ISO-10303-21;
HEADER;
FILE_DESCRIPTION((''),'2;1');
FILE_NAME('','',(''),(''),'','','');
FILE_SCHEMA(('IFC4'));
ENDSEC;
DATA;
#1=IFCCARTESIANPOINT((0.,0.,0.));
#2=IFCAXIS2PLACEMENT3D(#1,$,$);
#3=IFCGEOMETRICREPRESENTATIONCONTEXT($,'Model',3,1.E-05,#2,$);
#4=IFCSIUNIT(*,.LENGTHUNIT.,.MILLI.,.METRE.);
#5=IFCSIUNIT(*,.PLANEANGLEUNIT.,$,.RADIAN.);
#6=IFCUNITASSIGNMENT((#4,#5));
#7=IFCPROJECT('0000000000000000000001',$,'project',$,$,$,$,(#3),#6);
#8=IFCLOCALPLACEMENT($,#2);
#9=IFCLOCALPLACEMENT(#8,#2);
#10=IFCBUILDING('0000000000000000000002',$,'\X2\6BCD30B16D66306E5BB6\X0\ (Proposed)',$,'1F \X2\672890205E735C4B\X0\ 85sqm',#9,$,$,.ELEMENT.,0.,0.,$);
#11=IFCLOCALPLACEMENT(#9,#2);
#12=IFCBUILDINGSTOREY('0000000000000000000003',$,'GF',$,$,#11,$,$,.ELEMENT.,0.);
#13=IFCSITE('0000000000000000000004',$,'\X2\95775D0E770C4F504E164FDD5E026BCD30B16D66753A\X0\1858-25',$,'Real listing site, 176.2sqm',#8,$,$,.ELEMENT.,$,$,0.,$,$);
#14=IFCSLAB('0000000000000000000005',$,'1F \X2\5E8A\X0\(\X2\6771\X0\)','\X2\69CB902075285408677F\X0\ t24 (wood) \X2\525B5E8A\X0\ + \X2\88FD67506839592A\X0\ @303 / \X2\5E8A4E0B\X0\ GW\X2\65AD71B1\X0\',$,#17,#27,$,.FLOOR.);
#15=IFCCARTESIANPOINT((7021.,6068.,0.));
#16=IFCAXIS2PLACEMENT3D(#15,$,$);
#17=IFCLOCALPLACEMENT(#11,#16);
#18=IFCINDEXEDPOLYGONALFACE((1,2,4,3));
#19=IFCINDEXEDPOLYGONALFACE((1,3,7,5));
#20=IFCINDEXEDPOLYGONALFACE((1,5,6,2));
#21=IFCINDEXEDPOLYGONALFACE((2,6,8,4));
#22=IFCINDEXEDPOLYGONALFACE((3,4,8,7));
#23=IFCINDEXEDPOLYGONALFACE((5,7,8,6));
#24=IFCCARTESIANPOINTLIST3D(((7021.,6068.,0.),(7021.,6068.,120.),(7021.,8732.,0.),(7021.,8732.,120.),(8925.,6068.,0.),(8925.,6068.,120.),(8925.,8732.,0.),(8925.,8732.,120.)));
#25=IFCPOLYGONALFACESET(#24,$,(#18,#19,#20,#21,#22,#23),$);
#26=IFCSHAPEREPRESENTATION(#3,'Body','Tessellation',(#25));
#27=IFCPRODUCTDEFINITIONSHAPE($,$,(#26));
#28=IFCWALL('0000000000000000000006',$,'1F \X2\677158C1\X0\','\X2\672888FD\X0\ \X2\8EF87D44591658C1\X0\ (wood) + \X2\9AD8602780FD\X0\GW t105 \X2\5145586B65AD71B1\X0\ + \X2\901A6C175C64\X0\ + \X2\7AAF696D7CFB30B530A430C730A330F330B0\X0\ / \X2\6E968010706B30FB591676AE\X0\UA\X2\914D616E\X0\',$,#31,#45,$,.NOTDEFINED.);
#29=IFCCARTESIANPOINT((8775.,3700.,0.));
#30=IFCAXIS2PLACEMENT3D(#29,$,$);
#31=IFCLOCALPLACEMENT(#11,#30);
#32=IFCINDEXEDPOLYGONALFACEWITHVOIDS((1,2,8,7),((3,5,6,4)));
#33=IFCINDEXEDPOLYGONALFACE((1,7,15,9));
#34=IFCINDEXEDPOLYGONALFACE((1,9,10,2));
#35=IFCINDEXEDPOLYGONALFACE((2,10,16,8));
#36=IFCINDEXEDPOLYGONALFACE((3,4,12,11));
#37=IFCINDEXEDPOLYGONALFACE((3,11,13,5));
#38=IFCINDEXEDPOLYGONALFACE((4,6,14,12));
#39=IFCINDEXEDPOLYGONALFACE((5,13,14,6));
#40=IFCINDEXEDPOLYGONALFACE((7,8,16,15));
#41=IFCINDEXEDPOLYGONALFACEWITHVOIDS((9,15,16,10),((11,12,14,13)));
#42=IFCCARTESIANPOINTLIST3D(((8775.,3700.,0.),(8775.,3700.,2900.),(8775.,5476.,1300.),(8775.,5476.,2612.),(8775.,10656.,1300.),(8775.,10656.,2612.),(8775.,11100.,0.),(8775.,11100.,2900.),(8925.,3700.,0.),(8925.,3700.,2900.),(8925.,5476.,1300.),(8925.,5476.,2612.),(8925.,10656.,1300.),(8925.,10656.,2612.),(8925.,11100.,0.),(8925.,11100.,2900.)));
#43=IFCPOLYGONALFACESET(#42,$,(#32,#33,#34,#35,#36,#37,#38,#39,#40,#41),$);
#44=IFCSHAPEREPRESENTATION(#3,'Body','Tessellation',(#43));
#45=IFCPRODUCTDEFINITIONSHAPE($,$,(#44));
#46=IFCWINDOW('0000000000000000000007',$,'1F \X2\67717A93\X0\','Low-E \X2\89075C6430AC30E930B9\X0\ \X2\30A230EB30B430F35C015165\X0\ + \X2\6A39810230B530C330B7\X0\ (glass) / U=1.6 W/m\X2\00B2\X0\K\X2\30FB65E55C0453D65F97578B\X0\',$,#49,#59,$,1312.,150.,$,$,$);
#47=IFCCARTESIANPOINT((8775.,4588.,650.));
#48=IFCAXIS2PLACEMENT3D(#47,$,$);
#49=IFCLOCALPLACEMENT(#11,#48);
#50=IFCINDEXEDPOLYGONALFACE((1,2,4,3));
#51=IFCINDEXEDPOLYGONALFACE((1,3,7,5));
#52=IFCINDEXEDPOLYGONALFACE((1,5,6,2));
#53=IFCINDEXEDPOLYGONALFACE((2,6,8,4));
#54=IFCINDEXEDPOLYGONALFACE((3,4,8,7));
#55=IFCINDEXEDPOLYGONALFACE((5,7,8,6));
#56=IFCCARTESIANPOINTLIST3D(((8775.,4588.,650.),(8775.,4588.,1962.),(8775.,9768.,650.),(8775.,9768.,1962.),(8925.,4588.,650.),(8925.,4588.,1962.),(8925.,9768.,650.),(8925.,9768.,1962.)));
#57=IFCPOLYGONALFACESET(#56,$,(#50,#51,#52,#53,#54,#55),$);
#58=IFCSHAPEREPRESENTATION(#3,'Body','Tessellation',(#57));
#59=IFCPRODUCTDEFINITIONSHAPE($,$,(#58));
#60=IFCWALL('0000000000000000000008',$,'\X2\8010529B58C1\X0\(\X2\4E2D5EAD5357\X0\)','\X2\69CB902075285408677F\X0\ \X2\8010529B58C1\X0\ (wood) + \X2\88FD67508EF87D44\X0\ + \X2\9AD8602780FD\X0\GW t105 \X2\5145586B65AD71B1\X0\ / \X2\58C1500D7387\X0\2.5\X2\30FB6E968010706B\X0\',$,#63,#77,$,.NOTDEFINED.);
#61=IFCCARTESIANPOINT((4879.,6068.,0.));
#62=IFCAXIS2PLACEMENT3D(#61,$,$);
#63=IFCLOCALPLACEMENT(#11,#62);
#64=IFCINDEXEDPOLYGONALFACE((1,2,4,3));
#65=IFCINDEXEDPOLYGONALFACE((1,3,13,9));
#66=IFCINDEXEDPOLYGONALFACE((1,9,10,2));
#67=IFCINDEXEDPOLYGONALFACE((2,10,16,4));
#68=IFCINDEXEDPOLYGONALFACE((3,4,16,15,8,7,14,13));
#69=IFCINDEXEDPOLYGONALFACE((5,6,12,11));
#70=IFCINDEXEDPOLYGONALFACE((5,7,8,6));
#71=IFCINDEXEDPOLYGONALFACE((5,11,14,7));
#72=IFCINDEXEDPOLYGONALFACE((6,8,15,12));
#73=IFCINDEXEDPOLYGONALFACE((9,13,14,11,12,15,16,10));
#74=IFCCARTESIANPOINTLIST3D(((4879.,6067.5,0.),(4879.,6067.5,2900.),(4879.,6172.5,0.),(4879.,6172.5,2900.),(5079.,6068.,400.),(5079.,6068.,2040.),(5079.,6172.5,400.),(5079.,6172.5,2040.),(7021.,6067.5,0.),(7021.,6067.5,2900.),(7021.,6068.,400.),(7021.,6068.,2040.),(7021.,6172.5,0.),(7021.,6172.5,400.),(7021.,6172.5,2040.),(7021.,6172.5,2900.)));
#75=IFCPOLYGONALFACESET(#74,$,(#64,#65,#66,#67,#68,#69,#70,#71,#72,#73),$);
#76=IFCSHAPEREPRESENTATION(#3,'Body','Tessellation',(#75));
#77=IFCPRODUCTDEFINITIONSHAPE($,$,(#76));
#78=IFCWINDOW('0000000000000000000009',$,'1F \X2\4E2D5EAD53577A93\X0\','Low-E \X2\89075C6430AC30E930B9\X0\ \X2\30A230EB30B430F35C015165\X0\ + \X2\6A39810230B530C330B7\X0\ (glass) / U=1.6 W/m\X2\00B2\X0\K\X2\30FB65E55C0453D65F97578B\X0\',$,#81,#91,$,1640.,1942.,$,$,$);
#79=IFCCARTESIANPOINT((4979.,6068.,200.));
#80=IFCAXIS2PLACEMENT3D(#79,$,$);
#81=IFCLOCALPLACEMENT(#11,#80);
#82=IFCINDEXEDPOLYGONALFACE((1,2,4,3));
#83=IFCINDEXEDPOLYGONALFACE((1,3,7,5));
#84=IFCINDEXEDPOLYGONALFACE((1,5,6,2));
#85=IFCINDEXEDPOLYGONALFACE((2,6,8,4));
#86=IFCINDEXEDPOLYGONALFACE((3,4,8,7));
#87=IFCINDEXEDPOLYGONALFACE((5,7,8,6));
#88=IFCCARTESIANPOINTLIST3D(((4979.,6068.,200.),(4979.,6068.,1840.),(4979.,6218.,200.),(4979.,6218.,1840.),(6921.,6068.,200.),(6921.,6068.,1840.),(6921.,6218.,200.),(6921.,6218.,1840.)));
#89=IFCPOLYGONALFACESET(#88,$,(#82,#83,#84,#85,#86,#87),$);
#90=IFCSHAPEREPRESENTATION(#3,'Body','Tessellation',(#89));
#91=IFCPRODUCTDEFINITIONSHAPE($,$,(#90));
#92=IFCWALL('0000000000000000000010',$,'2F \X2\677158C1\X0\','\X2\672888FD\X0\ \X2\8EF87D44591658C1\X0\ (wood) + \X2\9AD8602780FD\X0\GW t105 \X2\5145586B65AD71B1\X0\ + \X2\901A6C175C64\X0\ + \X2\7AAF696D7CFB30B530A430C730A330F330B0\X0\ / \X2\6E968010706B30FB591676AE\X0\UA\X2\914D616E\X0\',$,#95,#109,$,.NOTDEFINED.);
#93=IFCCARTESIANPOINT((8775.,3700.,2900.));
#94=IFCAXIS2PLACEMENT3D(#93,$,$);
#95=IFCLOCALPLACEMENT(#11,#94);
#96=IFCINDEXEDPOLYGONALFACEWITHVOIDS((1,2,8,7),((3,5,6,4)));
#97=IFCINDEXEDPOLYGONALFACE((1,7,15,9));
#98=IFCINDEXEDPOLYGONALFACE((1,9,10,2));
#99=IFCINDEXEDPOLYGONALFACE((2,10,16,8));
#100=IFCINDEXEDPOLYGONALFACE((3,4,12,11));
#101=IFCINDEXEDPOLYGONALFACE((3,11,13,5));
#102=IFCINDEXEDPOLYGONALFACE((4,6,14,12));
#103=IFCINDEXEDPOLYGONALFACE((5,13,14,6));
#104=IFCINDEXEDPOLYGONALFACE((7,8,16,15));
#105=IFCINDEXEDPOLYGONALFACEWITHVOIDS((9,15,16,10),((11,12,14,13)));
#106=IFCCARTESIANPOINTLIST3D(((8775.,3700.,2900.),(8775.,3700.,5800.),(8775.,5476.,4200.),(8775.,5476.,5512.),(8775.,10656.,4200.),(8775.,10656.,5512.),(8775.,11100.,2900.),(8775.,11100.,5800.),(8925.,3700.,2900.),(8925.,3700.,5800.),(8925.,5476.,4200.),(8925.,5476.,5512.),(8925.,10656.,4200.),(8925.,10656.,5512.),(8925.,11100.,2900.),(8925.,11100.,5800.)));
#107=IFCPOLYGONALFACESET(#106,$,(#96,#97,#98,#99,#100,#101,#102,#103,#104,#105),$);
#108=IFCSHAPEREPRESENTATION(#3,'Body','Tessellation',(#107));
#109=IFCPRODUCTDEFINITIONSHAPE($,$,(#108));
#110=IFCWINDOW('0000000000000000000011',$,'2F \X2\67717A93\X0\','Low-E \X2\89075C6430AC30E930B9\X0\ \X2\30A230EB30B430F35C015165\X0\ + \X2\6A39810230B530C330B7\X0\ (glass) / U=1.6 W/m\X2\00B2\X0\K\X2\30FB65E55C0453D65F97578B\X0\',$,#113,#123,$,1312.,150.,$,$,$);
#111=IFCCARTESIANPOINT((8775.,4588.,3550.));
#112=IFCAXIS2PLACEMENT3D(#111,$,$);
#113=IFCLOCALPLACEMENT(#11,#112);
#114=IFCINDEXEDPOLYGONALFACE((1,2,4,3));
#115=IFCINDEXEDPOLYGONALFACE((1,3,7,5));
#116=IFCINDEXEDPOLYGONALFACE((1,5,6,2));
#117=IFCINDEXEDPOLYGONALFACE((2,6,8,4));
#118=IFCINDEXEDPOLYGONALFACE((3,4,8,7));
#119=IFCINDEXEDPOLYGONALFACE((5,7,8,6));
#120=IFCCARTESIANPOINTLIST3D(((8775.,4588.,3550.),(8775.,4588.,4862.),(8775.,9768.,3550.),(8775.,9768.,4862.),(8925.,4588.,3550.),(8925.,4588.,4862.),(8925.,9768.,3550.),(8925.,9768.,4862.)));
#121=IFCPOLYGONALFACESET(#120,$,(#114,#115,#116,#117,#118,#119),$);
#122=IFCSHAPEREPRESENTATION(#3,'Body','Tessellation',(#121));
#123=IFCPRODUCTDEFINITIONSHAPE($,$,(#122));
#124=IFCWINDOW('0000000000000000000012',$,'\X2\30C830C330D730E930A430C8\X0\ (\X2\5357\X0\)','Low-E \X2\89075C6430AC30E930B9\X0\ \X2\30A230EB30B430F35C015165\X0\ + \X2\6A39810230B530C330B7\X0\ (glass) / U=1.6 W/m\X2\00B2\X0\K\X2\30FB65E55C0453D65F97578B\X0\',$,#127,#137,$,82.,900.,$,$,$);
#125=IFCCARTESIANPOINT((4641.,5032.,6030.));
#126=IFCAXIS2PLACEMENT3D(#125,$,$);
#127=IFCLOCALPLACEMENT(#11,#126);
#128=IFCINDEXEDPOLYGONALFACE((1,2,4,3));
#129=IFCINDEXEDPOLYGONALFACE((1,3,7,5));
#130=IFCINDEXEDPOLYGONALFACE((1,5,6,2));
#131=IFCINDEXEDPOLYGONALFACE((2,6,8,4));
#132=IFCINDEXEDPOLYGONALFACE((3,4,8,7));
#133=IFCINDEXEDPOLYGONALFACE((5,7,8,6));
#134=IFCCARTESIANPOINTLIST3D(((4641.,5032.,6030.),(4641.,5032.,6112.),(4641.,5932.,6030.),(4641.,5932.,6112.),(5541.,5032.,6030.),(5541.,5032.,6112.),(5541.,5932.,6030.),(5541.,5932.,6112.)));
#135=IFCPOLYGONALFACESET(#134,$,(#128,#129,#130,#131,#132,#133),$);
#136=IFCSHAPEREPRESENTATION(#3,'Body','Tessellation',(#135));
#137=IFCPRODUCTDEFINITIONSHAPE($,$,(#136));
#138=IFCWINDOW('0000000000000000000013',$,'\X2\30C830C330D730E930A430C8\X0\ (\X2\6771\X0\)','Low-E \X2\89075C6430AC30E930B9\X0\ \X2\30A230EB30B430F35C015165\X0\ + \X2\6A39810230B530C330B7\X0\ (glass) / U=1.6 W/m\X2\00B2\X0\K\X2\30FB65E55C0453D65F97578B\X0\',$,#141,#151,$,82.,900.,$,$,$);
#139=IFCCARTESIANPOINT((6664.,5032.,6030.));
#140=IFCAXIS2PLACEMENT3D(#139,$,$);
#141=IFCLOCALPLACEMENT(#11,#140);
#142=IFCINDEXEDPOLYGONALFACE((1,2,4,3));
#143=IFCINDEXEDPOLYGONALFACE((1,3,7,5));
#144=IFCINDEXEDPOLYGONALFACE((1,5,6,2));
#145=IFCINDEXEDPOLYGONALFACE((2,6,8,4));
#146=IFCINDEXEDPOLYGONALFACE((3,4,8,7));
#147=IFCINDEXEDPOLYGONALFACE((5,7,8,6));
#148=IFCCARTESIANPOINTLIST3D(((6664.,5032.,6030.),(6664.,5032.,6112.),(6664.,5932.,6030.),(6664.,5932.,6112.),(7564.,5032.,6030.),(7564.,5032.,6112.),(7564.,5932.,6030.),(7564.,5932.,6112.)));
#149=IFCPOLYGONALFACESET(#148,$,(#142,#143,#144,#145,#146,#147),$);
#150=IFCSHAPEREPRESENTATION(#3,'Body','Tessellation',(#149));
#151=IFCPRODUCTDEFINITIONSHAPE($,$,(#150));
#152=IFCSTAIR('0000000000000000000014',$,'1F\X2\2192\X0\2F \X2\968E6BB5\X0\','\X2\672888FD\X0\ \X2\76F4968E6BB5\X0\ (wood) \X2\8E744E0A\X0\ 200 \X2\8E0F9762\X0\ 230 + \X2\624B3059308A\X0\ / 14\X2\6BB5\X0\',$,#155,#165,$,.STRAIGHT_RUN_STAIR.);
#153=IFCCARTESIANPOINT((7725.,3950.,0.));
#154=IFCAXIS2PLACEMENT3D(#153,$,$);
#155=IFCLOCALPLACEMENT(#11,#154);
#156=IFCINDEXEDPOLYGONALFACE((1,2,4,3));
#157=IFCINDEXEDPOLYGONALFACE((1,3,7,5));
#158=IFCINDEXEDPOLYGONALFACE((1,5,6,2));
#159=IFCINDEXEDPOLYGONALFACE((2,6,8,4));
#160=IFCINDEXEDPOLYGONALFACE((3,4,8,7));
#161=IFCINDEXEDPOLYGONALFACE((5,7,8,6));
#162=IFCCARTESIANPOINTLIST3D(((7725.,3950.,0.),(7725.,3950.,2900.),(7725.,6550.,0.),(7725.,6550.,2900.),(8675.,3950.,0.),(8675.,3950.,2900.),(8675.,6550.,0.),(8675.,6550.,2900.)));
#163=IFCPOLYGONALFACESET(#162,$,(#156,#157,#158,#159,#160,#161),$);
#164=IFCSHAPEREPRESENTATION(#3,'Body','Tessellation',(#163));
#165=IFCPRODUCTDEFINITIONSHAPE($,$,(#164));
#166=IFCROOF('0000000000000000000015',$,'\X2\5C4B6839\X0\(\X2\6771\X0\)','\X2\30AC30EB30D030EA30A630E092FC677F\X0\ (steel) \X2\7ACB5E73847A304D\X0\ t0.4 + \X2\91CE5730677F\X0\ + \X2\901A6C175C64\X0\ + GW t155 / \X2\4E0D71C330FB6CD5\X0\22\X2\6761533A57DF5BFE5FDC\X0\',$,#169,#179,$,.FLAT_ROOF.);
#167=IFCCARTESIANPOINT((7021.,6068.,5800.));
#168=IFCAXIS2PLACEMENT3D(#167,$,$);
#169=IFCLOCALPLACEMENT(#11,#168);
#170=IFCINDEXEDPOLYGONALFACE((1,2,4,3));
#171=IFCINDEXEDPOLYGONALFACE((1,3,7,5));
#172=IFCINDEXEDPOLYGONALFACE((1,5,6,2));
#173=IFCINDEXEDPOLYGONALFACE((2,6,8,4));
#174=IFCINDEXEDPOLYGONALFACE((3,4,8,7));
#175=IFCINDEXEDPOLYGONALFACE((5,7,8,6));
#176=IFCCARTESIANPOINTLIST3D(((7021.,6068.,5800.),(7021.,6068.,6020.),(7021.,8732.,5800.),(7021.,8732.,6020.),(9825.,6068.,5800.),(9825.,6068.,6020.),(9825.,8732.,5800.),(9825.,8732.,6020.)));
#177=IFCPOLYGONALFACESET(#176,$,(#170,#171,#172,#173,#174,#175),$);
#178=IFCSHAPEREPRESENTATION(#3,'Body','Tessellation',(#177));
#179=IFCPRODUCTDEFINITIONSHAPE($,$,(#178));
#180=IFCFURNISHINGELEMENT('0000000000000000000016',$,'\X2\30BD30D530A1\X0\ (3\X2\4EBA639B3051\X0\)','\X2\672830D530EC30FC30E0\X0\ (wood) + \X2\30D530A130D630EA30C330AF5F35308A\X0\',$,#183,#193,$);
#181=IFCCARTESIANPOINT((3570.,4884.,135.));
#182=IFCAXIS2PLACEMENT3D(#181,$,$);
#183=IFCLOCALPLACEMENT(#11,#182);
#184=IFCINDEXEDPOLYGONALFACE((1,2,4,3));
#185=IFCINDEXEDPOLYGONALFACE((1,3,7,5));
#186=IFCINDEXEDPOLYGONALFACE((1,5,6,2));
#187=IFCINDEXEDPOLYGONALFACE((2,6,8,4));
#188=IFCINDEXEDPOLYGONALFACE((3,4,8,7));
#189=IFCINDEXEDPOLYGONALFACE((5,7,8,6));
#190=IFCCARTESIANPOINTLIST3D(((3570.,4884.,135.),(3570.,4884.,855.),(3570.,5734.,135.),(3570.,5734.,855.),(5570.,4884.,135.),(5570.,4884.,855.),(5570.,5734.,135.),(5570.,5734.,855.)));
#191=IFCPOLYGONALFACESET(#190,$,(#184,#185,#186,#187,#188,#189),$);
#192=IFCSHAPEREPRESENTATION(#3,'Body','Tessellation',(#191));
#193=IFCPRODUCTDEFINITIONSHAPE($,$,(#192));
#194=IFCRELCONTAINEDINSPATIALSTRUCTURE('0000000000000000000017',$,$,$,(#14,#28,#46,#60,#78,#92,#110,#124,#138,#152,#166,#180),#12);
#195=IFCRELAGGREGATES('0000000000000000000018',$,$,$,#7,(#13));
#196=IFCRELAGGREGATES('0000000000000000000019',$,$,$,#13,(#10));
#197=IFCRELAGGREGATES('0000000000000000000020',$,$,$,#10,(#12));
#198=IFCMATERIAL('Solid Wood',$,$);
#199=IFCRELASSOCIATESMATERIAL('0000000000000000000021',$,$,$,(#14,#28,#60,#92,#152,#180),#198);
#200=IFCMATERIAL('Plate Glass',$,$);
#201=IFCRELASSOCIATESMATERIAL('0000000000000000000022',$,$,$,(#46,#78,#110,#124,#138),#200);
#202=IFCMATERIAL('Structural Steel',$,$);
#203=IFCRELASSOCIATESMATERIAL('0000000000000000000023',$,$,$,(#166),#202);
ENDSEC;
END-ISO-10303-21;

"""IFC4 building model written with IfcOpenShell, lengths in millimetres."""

from ifc_helpers import new_model, si_unit, frame, frame_2d, origin, place, context, project, spatial, rectangle, extrude, material, element, fill, save


model = new_model("IFC4")

# Units and contexts
model_context = context("Model", 3, precision=1e-05, world=origin())
ifc_project = project(units=[si_unit("LENGTHUNIT", "METRE", prefix="MILLI"), si_unit("PLANEANGLEUNIT", "RADIAN")], contexts=[model_context])

# Site, building, storey
site_placement = place(None, origin())
site = spatial("IfcSite", under=ifc_project, at=site_placement, Name="長崎県佐世保市母ケ浦町1858-25", ObjectType="Real listing site, 176.2sqm", CompositionType="ELEMENT", RefElevation=0.0)
building_placement = place(site_placement, origin())
building = spatial("IfcBuilding", under=site, at=building_placement, Name="母ケ浦の家 (Proposed)", ObjectType="1F 木造平屋 85sqm", CompositionType="ELEMENT", ElevationOfRefHeight=0.0, ElevationOfTerrain=0.0)
storey_placement = place(building_placement, origin())
storey = spatial("IfcBuildingStorey", under=building, at=storey_placement, Name="GF", CompositionType="ELEMENT", Elevation=0.0)

# Slab
ifc_material_1 = material(Name="Solid Wood")
slab_placement = place(storey_placement, frame((7021.0, 6068.0, 0.0)))
element("IfcSlab", 1, at=slab_placement, inside=storey, material=ifc_material_1, Name="1F 床(東)", Description="構造用合板 t24 (wood) 剛床 + 製材根太 @303 / 床下 GW断熱", PredefinedType="FLOOR", context=model_context, shape_type="SweptSolid", body=[
    extrude(rectangle(XDim=1904.0, YDim=2664.0, at=frame_2d((952.0, 1332.0))), frame((7021.0, 6068.0, 0.0)), (0.0, 0.0, 1.0), 120.0),
])

# Walls, openings, windows
wall_1_placement = place(storey_placement, frame((8775.0, 3700.0, 0.0)))
wall_1 = element("IfcWall", 2, at=wall_1_placement, inside=storey, material=ifc_material_1, Name="1F 東壁", Description="木製 軸組外壁 (wood) + 高性能GW t105 充填断熱 + 通気層 + 窯業系サイディング / 準耐火・外皮UA配慮", PredefinedType="NOTDEFINED", context=model_context, shape_type="SweptSolid", body=[
    extrude(rectangle(XDim=150.0, YDim=7400.0, at=frame_2d((75.0, 3700.0))), frame((8775.0, 3700.0, 0.0)), (0.0, 0.0, 1.0), 2900.0),
])
opening_1_placement = place(storey_placement, frame((8775.0, 4588.0, 650.0)))
opening_1 = element("IfcOpeningElement", 3, at=opening_1_placement, cuts=wall_1, PredefinedType="NOTDEFINED", context=model_context, shape_type="SweptSolid", body=[
    extrude(rectangle(XDim=150.0, YDim=5180.0, at=frame_2d((75.0, 2590.0))), frame((8775.0, 4588.0, 650.0)), (0.0, 0.0, 1.0), 1312.0),
])
ifc_material_2 = material(Name="Plate Glass")
window_1_placement = place(storey_placement, frame((8775.0, 4588.0, 650.0)))
window_1 = element("IfcWindow", 4, at=window_1_placement, inside=storey, material=ifc_material_2, Name="1F 東窓", Description="Low-E 複層ガラス アルゴン封入 + 樹脂サッシ (glass) / U=1.6 W/m²K・日射取得型", OverallHeight=1312.0, OverallWidth=150.0, context=model_context, shape_type="SweptSolid", body=[
    extrude(rectangle(XDim=150.0, YDim=5180.0, at=frame_2d((75.0, 2590.0))), frame((8775.0, 4588.0, 650.0)), (0.0, 0.0, 1.0), 1312.0),
])
fill(opening_1, window_1)
wall_2_placement = place(storey_placement, frame((4879.0, 6068.0, 0.0)))
wall_2 = element("IfcWall", 5, at=wall_2_placement, inside=storey, material=ifc_material_1, Name="耐力壁(中庭南)", Description="構造用合板 耐力壁 (wood) + 製材軸組 + 高性能GW t105 充填断熱 / 壁倍率2.5・準耐火", PredefinedType="NOTDEFINED", context=model_context, shape_type="SweptSolid", body=[
    extrude(rectangle(XDim=2142.0, YDim=105.0, at=frame_2d((1071.0, 52.0))), frame((4879.0, 6068.0, 0.0)), (0.0, 0.0, 1.0), 2900.0),
])
opening_2_placement = place(storey_placement, frame((4979.0, 6068.0, 200.0)))
opening_2 = element("IfcOpeningElement", 6, at=opening_2_placement, cuts=wall_2, PredefinedType="NOTDEFINED", context=model_context, shape_type="SweptSolid", body=[
    extrude(rectangle(XDim=1942.0, YDim=150.0, at=frame_2d((971.0, 75.0))), frame((4979.0, 6068.0, 200.0)), (0.0, 0.0, 1.0), 1640.0),
])
window_2_placement = place(storey_placement, frame((4979.0, 6068.0, 200.0)))
window_2 = element("IfcWindow", 7, at=window_2_placement, inside=storey, material=ifc_material_2, Name="1F 中庭南窓", Description="Low-E 複層ガラス アルゴン封入 + 樹脂サッシ (glass) / U=1.6 W/m²K・日射取得型", OverallHeight=1640.0, OverallWidth=1942.0, context=model_context, shape_type="SweptSolid", body=[
    extrude(rectangle(XDim=1942.0, YDim=150.0, at=frame_2d((971.0, 75.0))), frame((4979.0, 6068.0, 200.0)), (0.0, 0.0, 1.0), 1640.0),
])
fill(opening_2, window_2)

# Wall, opening, window
wall_3_placement = place(storey_placement, frame((8775.0, 3700.0, 2900.0)))
wall_3 = element("IfcWall", 8, at=wall_3_placement, inside=storey, material=ifc_material_1, Name="2F 東壁", Description="木製 軸組外壁 (wood) + 高性能GW t105 充填断熱 + 通気層 + 窯業系サイディング / 準耐火・外皮UA配慮", PredefinedType="NOTDEFINED", context=model_context, shape_type="SweptSolid", body=[
    extrude(rectangle(XDim=150.0, YDim=7400.0, at=frame_2d((75.0, 3700.0))), frame((8775.0, 3700.0, 2900.0)), (0.0, 0.0, 1.0), 2900.0),
])
opening_3_placement = place(storey_placement, frame((8775.0, 4588.0, 3550.0)))
opening_3 = element("IfcOpeningElement", 9, at=opening_3_placement, cuts=wall_3, PredefinedType="NOTDEFINED", context=model_context, shape_type="SweptSolid", body=[
    extrude(rectangle(XDim=150.0, YDim=5180.0, at=frame_2d((75.0, 2590.0))), frame((8775.0, 4588.0, 3550.0)), (0.0, 0.0, 1.0), 1312.0),
])
window_3_placement = place(storey_placement, frame((8775.0, 4588.0, 3550.0)))
window_3 = element("IfcWindow", 10, at=window_3_placement, inside=storey, material=ifc_material_2, Name="2F 東窓", Description="Low-E 複層ガラス アルゴン封入 + 樹脂サッシ (glass) / U=1.6 W/m²K・日射取得型", OverallHeight=1312.0, OverallWidth=150.0, context=model_context, shape_type="SweptSolid", body=[
    extrude(rectangle(XDim=150.0, YDim=5180.0, at=frame_2d((75.0, 2590.0))), frame((8775.0, 4588.0, 3550.0)), (0.0, 0.0, 1.0), 1312.0),
])
fill(opening_3, window_3)

# Windows
window_4_placement = place(storey_placement, frame((4641.0, 5032.0, 6030.0)))
element("IfcWindow", 11, at=window_4_placement, inside=storey, material=ifc_material_2, Name="トップライト (南)", Description="Low-E 複層ガラス アルゴン封入 + 樹脂サッシ (glass) / U=1.6 W/m²K・日射取得型", OverallHeight=82.0, OverallWidth=900.0, context=model_context, shape_type="SweptSolid", body=[
    extrude(rectangle(XDim=900.0, YDim=900.0, at=frame_2d((450.0, 450.0))), frame((4641.0, 5032.0, 6030.0)), (0.0, 0.0, 1.0), 82.0),
])
window_5_placement = place(storey_placement, frame((6664.0, 5032.0, 6030.0)))
element("IfcWindow", 12, at=window_5_placement, inside=storey, material=ifc_material_2, Name="トップライト (東)", Description="Low-E 複層ガラス アルゴン封入 + 樹脂サッシ (glass) / U=1.6 W/m²K・日射取得型", OverallHeight=82.0, OverallWidth=900.0, context=model_context, shape_type="SweptSolid", body=[
    extrude(rectangle(XDim=900.0, YDim=900.0, at=frame_2d((450.0, 450.0))), frame((6664.0, 5032.0, 6030.0)), (0.0, 0.0, 1.0), 82.0),
])

# Stair
stair_placement = place(storey_placement, frame((7725.0, 3950.0, 0.0)))
element("IfcStair", 13, at=stair_placement, inside=storey, material=ifc_material_1, Name="1F→2F 階段", Description="木製 直階段 (wood) 蹴上 200 踏面 230 + 手すり / 14段", PredefinedType="STRAIGHT_RUN_STAIR", context=model_context, shape_type="SweptSolid", body=[
    extrude(rectangle(XDim=950.0, YDim=2600.0, at=frame_2d((475.0, 1300.0))), frame((7725.0, 3950.0, 0.0)), (0.0, 0.0, 1.0), 2900.0),
])

# Roof
ifc_material_3 = material(Name="Structural Steel")
roof_placement = place(storey_placement, frame((7021.0, 6068.0, 5800.0)))
element("IfcRoof", 14, at=roof_placement, inside=storey, material=ifc_material_3, Name="屋根(東)", Description="ガルバリウム鋼板 (steel) 立平葺き t0.4 + 野地板 + 通気層 + GW t155 / 不燃・法22条区域対応", PredefinedType="FLAT_ROOF", context=model_context, shape_type="SweptSolid", body=[
    extrude(rectangle(XDim=2804.0, YDim=2664.0, at=frame_2d((1402.0, 1332.0))), frame((7021.0, 6068.0, 5800.0)), (0.0, 0.0, 1.0), 220.0),
])

# Furnishing element
furnishing_1_placement = place(storey_placement, frame((3570.0, 4884.0, 135.0)))
element("IfcFurnishingElement", 15, at=furnishing_1_placement, inside=storey, material=ifc_material_1, Name="ソファ (3人掛け)", Description="木フレーム (wood) + ファブリック張り", context=model_context, shape_type="SweptSolid", body=[
    extrude(rectangle(XDim=2000.0, YDim=850.0, at=frame_2d((1000.0, 425.0))), frame((3570.0, 4884.0, 135.0)), (0.0, 0.0, 1.0), 720.0),
])

save(model, "model.ifc")
